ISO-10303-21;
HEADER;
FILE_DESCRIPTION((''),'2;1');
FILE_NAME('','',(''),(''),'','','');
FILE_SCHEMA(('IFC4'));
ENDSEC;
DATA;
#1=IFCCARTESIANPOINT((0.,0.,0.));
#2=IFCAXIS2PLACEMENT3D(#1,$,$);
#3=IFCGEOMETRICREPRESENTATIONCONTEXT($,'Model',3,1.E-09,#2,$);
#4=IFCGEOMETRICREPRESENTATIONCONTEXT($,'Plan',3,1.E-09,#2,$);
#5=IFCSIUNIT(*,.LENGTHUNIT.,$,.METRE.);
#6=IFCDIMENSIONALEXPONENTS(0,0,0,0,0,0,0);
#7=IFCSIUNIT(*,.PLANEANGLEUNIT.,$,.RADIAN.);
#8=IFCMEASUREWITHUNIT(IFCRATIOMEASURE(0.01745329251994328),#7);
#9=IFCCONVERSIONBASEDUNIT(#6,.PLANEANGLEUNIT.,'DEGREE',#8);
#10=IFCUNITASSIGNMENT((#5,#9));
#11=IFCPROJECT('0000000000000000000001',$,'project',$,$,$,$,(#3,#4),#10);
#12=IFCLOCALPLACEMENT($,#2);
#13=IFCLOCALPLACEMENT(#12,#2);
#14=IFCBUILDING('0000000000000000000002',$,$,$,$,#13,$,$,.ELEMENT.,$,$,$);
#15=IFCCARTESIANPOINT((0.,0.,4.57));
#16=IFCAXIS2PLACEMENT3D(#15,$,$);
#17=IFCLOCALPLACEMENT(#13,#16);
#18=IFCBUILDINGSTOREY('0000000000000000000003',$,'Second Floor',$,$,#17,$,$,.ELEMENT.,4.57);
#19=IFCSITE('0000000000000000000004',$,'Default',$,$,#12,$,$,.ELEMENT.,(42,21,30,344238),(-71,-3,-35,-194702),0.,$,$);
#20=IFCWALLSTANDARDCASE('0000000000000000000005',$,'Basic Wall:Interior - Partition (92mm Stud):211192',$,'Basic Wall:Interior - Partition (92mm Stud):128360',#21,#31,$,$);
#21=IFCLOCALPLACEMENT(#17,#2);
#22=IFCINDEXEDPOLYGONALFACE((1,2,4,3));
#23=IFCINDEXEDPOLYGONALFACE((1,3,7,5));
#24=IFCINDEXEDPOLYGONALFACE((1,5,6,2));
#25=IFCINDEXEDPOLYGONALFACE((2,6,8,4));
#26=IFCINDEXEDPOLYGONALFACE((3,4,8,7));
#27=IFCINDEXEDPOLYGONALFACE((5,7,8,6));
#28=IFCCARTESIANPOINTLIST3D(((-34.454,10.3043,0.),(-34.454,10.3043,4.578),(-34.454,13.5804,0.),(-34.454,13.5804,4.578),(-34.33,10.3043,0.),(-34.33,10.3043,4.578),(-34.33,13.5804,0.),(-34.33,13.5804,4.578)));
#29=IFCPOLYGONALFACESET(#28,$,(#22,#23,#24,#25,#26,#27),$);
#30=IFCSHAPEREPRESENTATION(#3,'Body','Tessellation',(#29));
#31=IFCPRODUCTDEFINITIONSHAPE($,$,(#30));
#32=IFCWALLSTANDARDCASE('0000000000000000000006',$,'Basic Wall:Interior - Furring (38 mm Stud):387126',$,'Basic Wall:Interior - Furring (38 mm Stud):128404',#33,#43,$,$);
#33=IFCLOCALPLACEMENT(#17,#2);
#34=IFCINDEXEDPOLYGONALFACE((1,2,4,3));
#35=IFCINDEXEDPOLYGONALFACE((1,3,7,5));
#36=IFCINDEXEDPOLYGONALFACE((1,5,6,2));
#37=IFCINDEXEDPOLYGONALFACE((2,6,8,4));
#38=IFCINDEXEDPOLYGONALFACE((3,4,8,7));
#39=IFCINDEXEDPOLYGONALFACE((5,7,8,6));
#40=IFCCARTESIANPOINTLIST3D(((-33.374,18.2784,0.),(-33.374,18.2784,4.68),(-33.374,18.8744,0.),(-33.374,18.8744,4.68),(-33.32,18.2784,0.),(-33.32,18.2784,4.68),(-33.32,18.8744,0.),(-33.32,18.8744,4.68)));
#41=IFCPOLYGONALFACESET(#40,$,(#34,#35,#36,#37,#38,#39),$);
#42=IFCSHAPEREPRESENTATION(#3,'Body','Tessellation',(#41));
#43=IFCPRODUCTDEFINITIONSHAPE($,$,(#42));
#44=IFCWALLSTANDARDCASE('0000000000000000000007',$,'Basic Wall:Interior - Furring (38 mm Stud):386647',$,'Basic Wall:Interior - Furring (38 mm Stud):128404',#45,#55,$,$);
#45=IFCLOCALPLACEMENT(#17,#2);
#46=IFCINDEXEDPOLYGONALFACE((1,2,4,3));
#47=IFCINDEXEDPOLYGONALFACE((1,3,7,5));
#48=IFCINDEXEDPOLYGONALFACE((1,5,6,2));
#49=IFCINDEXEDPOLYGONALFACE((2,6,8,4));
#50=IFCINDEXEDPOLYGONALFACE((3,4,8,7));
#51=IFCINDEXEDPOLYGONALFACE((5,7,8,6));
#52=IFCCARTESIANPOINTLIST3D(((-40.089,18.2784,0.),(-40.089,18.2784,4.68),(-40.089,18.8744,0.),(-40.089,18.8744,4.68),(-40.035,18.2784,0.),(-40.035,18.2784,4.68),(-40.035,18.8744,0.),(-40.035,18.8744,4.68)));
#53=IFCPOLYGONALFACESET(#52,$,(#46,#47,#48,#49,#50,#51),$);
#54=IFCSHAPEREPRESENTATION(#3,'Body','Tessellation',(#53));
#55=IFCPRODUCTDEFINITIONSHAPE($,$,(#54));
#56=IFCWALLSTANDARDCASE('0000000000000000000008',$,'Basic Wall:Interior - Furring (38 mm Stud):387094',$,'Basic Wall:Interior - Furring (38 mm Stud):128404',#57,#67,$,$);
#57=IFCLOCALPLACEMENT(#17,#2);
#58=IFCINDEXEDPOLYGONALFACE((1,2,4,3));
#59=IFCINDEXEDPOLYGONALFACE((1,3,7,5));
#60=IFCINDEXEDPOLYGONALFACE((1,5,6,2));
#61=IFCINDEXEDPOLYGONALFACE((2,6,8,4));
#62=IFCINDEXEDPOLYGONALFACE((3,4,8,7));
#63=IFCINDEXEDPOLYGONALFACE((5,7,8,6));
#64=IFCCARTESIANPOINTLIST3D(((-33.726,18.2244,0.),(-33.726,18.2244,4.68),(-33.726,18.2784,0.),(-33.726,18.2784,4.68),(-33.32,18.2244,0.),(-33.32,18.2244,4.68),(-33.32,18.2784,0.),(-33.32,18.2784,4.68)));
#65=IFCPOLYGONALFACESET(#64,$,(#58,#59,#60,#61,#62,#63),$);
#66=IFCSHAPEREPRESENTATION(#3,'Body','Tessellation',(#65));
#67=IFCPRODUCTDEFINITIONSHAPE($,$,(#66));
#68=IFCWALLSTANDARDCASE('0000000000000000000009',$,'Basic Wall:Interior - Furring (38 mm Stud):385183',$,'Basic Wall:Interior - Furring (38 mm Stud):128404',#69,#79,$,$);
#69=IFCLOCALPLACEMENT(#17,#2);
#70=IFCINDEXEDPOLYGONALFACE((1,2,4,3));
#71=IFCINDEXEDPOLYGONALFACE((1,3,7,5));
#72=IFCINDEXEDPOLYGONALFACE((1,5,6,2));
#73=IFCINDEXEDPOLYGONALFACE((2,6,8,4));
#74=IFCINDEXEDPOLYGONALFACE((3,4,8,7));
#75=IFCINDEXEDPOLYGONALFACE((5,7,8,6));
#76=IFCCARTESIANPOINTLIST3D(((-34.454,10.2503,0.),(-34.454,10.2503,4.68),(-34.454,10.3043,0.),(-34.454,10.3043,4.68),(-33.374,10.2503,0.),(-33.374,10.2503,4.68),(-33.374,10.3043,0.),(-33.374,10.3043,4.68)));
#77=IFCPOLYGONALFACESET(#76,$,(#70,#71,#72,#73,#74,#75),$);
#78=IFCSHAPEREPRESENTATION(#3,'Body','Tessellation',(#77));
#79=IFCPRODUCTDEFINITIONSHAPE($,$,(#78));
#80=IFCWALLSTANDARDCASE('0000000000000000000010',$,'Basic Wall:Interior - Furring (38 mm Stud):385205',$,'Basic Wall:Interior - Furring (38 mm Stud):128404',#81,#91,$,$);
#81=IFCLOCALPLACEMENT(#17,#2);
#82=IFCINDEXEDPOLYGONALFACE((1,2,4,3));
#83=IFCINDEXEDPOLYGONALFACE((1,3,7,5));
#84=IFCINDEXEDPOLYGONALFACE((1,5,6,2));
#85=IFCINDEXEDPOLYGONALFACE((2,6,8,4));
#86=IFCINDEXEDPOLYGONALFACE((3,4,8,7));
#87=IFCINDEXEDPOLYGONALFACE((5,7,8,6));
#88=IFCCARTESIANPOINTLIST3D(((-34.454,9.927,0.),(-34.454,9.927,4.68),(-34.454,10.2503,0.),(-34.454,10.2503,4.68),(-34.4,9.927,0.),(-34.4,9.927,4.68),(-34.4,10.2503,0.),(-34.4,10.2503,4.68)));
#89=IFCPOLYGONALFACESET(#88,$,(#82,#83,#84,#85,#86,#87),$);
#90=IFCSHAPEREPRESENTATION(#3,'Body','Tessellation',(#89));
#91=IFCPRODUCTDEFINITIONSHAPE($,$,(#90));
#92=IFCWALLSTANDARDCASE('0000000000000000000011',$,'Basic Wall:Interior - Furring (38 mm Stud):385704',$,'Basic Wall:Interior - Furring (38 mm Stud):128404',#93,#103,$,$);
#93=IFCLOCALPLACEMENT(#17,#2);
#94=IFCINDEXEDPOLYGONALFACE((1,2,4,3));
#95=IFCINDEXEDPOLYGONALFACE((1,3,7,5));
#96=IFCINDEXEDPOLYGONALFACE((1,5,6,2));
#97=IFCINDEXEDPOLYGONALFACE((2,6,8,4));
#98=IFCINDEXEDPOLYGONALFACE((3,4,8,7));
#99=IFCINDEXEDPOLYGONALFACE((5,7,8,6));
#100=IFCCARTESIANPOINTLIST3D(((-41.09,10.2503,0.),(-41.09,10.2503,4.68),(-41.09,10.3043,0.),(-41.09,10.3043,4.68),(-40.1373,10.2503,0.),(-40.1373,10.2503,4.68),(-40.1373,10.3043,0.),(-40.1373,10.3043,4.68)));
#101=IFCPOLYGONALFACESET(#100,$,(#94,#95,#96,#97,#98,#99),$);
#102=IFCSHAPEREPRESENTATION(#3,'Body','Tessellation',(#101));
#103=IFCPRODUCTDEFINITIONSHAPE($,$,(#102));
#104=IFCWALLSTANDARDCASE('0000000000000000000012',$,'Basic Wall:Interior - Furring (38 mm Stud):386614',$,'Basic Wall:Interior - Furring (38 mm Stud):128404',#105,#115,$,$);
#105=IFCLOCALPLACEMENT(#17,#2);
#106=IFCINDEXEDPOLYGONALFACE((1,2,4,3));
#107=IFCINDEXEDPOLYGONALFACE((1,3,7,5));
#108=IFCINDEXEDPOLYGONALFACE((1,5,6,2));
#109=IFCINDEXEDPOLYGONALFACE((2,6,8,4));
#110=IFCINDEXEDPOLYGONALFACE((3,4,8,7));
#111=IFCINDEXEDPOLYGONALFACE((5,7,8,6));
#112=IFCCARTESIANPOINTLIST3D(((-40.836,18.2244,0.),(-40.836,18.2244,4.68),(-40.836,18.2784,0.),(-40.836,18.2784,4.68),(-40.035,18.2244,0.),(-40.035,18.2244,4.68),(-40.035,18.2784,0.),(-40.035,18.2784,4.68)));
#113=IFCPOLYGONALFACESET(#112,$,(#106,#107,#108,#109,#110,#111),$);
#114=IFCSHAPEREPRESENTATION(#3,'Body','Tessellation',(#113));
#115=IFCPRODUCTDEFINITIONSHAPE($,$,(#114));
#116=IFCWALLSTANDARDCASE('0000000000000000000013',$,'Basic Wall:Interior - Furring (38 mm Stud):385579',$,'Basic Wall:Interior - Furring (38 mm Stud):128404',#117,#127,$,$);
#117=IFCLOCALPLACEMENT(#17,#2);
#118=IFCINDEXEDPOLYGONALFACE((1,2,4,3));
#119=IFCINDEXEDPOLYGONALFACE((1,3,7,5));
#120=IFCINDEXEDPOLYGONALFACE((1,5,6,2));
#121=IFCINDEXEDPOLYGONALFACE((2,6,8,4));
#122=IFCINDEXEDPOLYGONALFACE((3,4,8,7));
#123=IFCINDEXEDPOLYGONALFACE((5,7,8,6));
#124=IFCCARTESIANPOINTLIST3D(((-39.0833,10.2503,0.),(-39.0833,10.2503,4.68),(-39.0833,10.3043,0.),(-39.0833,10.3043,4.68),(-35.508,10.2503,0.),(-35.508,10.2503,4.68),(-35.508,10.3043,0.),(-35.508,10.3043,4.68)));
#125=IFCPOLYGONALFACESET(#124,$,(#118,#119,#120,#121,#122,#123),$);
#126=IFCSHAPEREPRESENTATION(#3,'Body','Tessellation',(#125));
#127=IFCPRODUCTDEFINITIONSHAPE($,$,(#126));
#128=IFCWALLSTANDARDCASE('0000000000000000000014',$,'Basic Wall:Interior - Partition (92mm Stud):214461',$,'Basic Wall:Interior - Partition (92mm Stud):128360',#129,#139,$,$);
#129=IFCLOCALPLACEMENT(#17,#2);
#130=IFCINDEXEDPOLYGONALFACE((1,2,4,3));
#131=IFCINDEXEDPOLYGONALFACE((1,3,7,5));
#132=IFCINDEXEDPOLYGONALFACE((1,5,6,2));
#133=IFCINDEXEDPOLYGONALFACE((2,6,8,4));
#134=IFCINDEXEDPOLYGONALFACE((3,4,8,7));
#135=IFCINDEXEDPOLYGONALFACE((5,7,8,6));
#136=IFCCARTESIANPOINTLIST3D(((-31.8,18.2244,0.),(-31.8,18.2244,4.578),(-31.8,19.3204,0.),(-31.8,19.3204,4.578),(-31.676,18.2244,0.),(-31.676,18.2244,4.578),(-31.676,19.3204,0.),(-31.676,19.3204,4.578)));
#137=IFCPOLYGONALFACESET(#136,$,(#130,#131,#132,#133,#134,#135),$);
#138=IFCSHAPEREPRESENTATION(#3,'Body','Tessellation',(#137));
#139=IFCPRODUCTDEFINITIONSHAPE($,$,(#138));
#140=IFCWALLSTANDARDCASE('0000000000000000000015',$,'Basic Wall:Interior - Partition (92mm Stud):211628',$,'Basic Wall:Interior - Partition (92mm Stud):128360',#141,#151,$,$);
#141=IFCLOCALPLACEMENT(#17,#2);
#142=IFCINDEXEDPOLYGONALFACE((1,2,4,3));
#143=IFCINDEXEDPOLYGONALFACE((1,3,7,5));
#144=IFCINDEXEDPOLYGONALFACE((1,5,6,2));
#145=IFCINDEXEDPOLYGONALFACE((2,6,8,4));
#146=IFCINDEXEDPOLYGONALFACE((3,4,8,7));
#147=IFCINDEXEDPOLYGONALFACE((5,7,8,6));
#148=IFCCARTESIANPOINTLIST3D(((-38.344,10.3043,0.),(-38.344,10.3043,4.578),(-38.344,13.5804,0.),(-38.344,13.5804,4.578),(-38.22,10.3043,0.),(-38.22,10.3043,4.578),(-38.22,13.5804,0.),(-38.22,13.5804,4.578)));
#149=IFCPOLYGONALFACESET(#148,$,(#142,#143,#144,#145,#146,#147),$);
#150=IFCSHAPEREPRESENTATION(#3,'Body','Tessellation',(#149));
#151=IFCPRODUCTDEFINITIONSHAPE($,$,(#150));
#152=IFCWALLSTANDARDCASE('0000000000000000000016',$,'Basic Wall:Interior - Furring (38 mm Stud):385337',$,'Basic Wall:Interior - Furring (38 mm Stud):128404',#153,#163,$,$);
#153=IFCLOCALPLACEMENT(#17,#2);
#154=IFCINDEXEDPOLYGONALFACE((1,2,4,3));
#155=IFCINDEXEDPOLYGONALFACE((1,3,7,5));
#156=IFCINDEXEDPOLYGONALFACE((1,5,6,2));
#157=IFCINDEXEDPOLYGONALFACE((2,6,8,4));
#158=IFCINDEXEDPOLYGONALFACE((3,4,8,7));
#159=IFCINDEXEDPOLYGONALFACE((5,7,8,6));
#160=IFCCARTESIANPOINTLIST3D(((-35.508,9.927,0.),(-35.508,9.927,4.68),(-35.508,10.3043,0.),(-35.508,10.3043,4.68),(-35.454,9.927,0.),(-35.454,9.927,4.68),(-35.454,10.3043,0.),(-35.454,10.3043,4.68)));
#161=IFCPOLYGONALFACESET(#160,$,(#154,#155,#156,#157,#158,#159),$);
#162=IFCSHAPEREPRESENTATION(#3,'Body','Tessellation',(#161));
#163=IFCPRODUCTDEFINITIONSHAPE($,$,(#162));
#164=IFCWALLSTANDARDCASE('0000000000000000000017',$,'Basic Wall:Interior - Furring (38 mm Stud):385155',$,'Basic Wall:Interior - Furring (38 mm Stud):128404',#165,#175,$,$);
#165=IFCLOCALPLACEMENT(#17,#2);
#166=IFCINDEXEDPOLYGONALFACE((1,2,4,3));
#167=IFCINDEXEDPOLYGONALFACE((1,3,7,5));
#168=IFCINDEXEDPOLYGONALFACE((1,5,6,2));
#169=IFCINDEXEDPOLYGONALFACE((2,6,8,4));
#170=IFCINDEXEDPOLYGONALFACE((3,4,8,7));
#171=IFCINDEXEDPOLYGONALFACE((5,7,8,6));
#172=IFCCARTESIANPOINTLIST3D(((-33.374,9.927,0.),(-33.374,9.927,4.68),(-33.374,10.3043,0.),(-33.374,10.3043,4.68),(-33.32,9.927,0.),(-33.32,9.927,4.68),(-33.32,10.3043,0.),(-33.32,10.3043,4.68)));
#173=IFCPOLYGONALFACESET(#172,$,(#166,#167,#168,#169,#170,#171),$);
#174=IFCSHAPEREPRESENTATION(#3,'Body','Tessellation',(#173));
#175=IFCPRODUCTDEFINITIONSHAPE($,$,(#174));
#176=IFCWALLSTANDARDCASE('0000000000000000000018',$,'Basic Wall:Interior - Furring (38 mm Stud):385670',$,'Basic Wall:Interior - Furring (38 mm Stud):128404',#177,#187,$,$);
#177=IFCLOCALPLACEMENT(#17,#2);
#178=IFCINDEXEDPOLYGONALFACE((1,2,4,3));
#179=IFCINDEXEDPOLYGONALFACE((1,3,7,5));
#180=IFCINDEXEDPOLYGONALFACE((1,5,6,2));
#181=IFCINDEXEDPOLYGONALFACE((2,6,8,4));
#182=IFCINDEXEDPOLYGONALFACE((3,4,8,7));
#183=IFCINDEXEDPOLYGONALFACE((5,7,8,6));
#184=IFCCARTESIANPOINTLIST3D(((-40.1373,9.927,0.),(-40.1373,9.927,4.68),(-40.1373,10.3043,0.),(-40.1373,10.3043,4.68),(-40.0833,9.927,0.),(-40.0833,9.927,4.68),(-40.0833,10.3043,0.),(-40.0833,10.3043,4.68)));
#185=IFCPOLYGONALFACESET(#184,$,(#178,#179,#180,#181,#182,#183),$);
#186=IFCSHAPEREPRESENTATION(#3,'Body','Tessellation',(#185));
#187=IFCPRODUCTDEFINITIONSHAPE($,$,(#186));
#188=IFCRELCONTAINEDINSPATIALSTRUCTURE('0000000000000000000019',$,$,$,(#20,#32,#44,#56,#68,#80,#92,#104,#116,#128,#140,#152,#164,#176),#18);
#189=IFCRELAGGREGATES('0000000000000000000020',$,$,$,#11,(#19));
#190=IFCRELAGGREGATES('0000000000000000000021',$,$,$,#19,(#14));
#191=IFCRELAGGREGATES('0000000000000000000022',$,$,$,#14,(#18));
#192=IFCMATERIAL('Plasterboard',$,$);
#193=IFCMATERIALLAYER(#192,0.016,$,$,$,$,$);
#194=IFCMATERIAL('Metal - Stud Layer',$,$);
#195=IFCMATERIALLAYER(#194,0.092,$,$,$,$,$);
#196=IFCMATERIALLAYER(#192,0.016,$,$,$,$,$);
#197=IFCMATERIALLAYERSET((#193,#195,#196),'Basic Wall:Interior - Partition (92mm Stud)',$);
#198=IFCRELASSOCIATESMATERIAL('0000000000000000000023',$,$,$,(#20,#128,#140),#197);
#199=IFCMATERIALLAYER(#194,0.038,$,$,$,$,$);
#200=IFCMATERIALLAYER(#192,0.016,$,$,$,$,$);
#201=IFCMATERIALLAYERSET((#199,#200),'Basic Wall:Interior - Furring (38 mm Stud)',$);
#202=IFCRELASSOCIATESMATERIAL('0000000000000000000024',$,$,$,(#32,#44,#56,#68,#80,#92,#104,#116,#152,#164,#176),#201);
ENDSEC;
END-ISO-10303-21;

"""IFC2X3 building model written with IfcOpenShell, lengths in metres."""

from ifc_helpers import new_model, entity, si_unit, converted_unit, frame, frame_2d, origin, place, context, project, spatial, rectangle, extrude, material, layer, layer_set, layer_usage, element, save


model = new_model("IFC2X3")

# Units and contexts
model_context = context("Model", 3, precision=1e-09, world=origin())
plan_context = context("Plan", 3, precision=1e-09, world=origin())
ifc_project = project(units=[si_unit("LENGTHUNIT", "METRE"), converted_unit("PLANEANGLEUNIT", "DEGREE", entity("IfcRatioMeasure", 0.01745329251994328), si_unit("PLANEANGLEUNIT", "RADIAN"), dimensions=[0, 0, 0, 0, 0, 0, 0])], contexts=[model_context, plan_context])

# Site, building, storey
site_placement = place(None, origin())
site = spatial("IfcSite", under=ifc_project, at=site_placement, Name="Default", CompositionType="ELEMENT", RefLatitude=(42, 21, 30, 344238), RefLongitude=(-71, -3, -35, -194702), RefElevation=0.0)
building_placement = place(site_placement, origin())
building = spatial("IfcBuilding", under=site, at=building_placement, CompositionType="ELEMENT")
storey_placement = place(building_placement, frame((0.0, 0.0, 4.57)))
storey = spatial("IfcBuildingStorey", under=building, at=storey_placement, Name="Second Floor", CompositionType="ELEMENT", Elevation=4.57)

# Shared definitions
ifc_material_1 = material(Name="Plasterboard")
ifc_layer_1 = layer(ifc_material_1, 0.016)
ifc_material_2 = material(Name="Metal - Stud Layer")
ifc_layer_2 = layer(ifc_material_2, 0.092)
ifc_layer_3 = layer(ifc_material_1, 0.016)
ifc_layer_set_1 = layer_set([ifc_layer_1, ifc_layer_2, ifc_layer_3], Name="Basic Wall:Interior - Partition (92mm Stud)")
ifc_layer_usage_1 = layer_usage(ifc_layer_set_1, "AXIS2", "NEGATIVE", 0.062)

# Walls
wall_1_placement = place(storey_placement, frame((-34.392, 13.5804, 0.0), z_axis=(0.0, 0.0, 1.0), x_axis=(0.0, -1.0, 0.0)))
element("IfcWallStandardCase", 1, at=wall_1_placement, inside=storey, material=ifc_layer_usage_1, Name="Basic Wall:Interior - Partition (92mm Stud):211192", ObjectType="Basic Wall:Interior - Partition (92mm Stud):128360", context=model_context, shape_type="SweptSolid", body=[
    extrude(rectangle(XDim=3.2761, YDim=0.124, at=frame_2d((1.6381, 0.0), x_axis=(-1.0, 0.0))), origin(), (0.0, 0.0, 1.0), 4.578),
])
ifc_layer_4 = layer(ifc_material_2, 0.038)
ifc_layer_5 = layer(ifc_material_1, 0.016)
ifc_layer_set_2 = layer_set([ifc_layer_4, ifc_layer_5], Name="Basic Wall:Interior - Furring (38 mm Stud)")
ifc_layer_usage_2 = layer_usage(ifc_layer_set_2, "AXIS2", "NEGATIVE", 0.027)
wall_2_placement = place(storey_placement, frame((-33.347, 18.2784, 0.0), z_axis=(0.0, 0.0, 1.0), x_axis=(0.0, 1.0, 0.0)))
element("IfcWallStandardCase", 2, at=wall_2_placement, inside=storey, material=ifc_layer_usage_2, Name="Basic Wall:Interior - Furring (38 mm Stud):387126", ObjectType="Basic Wall:Interior - Furring (38 mm Stud):128404", context=model_context, shape_type="SweptSolid", body=[
    extrude(rectangle(XDim=0.596, YDim=0.054, at=frame_2d((0.298, 0.0), x_axis=(-1.0, 0.0))), origin(), (0.0, 0.0, 1.0), 4.68),
])
wall_3_placement = place(storey_placement, frame((-40.062, 18.2784, 0.0), z_axis=(0.0, 0.0, 1.0), x_axis=(0.0, 1.0, 0.0)))
element("IfcWallStandardCase", 3, at=wall_3_placement, inside=storey, material=ifc_layer_usage_2, Name="Basic Wall:Interior - Furring (38 mm Stud):386647", ObjectType="Basic Wall:Interior - Furring (38 mm Stud):128404", context=model_context, shape_type="SweptSolid", body=[
    extrude(rectangle(XDim=0.596, YDim=0.054, at=frame_2d((0.298, 0.0), x_axis=(-1.0, 0.0))), origin(), (0.0, 0.0, 1.0), 4.68),
])
wall_4_placement = place(storey_placement, frame((-33.726, 18.2514, 0.0)))
element("IfcWallStandardCase", 4, at=wall_4_placement, inside=storey, material=ifc_layer_usage_2, Name="Basic Wall:Interior - Furring (38 mm Stud):387094", ObjectType="Basic Wall:Interior - Furring (38 mm Stud):128404", context=model_context, shape_type="SweptSolid", body=[
    extrude(rectangle(XDim=0.406, YDim=0.054, at=frame_2d((0.203, 0.0), x_axis=(-1.0, 0.0))), origin(), (0.0, 0.0, 1.0), 4.68),
])
wall_5_placement = place(storey_placement, frame((-33.374, 10.2773, 0.0), z_axis=(0.0, 0.0, 1.0), x_axis=(-1.0, 0.0, 0.0)))
element("IfcWallStandardCase", 5, at=wall_5_placement, inside=storey, material=ifc_layer_usage_2, Name="Basic Wall:Interior - Furring (38 mm Stud):385183", ObjectType="Basic Wall:Interior - Furring (38 mm Stud):128404", context=model_context, shape_type="SweptSolid", body=[
    extrude(rectangle(XDim=1.08, YDim=0.054, at=frame_2d((0.54, 0.0), x_axis=(-1.0, 0.0))), origin(), (0.0, 0.0, 1.0), 4.68),
])
wall_6_placement = place(storey_placement, frame((-34.427, 10.2503, 0.0), z_axis=(0.0, 0.0, 1.0), x_axis=(0.0, -1.0, 0.0)))
element("IfcWallStandardCase", 6, at=wall_6_placement, inside=storey, material=ifc_layer_usage_2, Name="Basic Wall:Interior - Furring (38 mm Stud):385205", ObjectType="Basic Wall:Interior - Furring (38 mm Stud):128404", context=model_context, shape_type="SweptSolid", body=[
    extrude(rectangle(XDim=0.3233, YDim=0.054, at=frame_2d((0.1617, 0.0), x_axis=(-1.0, 0.0))), origin(), (0.0, 0.0, 1.0), 4.68),
])
wall_7_placement = place(storey_placement, frame((-40.1373, 10.2773, 0.0), z_axis=(0.0, 0.0, 1.0), x_axis=(-1.0, 0.0, 0.0)))
element("IfcWallStandardCase", 7, at=wall_7_placement, inside=storey, material=ifc_layer_usage_2, Name="Basic Wall:Interior - Furring (38 mm Stud):385704", ObjectType="Basic Wall:Interior - Furring (38 mm Stud):128404", context=model_context, shape_type="SweptSolid", body=[
    extrude(rectangle(XDim=0.9527, YDim=0.054, at=frame_2d((0.4763, 0.0), x_axis=(-1.0, 0.0))), origin(), (0.0, 0.0, 1.0), 4.68),
])
wall_8_placement = place(storey_placement, frame((-40.836, 18.2514, 0.0)))
element("IfcWallStandardCase", 8, at=wall_8_placement, inside=storey, material=ifc_layer_usage_2, Name="Basic Wall:Interior - Furring (38 mm Stud):386614", ObjectType="Basic Wall:Interior - Furring (38 mm Stud):128404", context=model_context, shape_type="SweptSolid", body=[
    extrude(rectangle(XDim=0.801, YDim=0.054, at=frame_2d((0.4005, 0.0), x_axis=(-1.0, 0.0))), origin(), (0.0, 0.0, 1.0), 4.68),
])
wall_9_placement = place(storey_placement, frame((-35.508, 10.2773, 0.0), z_axis=(0.0, 0.0, 1.0), x_axis=(-1.0, 0.0, 0.0)))
element("IfcWallStandardCase", 9, at=wall_9_placement, inside=storey, material=ifc_layer_usage_2, Name="Basic Wall:Interior - Furring (38 mm Stud):385579", ObjectType="Basic Wall:Interior - Furring (38 mm Stud):128404", context=model_context, shape_type="SweptSolid", body=[
    extrude(rectangle(XDim=3.5753, YDim=0.054, at=frame_2d((1.7876, 0.0), x_axis=(-1.0, 0.0))), origin(), (0.0, 0.0, 1.0), 4.68),
])
wall_10_placement = place(storey_placement, frame((-31.738, 18.2244, 0.0), z_axis=(0.0, 0.0, 1.0), x_axis=(0.0, 1.0, 0.0)))
element("IfcWallStandardCase", 10, at=wall_10_placement, inside=storey, material=ifc_layer_usage_1, Name="Basic Wall:Interior - Partition (92mm Stud):214461", ObjectType="Basic Wall:Interior - Partition (92mm Stud):128360", context=model_context, shape_type="SweptSolid", body=[
    extrude(rectangle(XDim=1.096, YDim=0.124, at=frame_2d((0.548, 0.0), x_axis=(-1.0, 0.0))), origin(), (0.0, 0.0, 1.0), 4.578),
])
wall_11_placement = place(storey_placement, frame((-38.282, 13.5804, 0.0), z_axis=(0.0, 0.0, 1.0), x_axis=(0.0, -1.0, 0.0)))
element("IfcWallStandardCase", 11, at=wall_11_placement, inside=storey, material=ifc_layer_usage_1, Name="Basic Wall:Interior - Partition (92mm Stud):211628", ObjectType="Basic Wall:Interior - Partition (92mm Stud):128360", context=model_context, shape_type="SweptSolid", body=[
    extrude(rectangle(XDim=3.2761, YDim=0.124, at=frame_2d((1.6381, 0.0), x_axis=(-1.0, 0.0))), origin(), (0.0, 0.0, 1.0), 4.578),
])
for number, where, z_axis, x_axis, name in (
    (12, (-35.481, 9.927, 0.0), (0.0, 0.0, 1.0), (0.0, 1.0, 0.0), "Basic Wall:Interior - Furring (38 mm Stud):385337"),
    (13, (-33.347, 9.927, 0.0), (0.0, 0.0, 1.0), (0.0, 1.0, 0.0), "Basic Wall:Interior - Furring (38 mm Stud):385155"),
):
    element("IfcWallStandardCase", number, at=place(storey_placement, frame(where, z_axis=z_axis, x_axis=x_axis)), inside=storey, material=ifc_layer_usage_2, Name=name, ObjectType="Basic Wall:Interior - Furring (38 mm Stud):128404", context=model_context, shape_type="SweptSolid", body=[
        extrude(rectangle(XDim=0.3773, YDim=0.054, at=frame_2d((0.1887, 0.0), x_axis=(-1.0, 0.0))), origin(), (0.0, 0.0, 1.0), 4.68),
    ])
wall_12_placement = place(storey_placement, frame((-40.1103, 9.927, 0.0), z_axis=(0.0, 0.0, 1.0), x_axis=(0.0, 1.0, 0.0)))
element("IfcWallStandardCase", 14, at=wall_12_placement, inside=storey, material=ifc_layer_usage_2, Name="Basic Wall:Interior - Furring (38 mm Stud):385670", ObjectType="Basic Wall:Interior - Furring (38 mm Stud):128404", context=model_context, shape_type="SweptSolid", body=[
    extrude(rectangle(XDim=0.3773, YDim=0.054, at=frame_2d((0.1887, 0.0), x_axis=(-1.0, 0.0))), origin(), (0.0, 0.0, 1.0), 4.68),
])

save(model, "model.ifc")
